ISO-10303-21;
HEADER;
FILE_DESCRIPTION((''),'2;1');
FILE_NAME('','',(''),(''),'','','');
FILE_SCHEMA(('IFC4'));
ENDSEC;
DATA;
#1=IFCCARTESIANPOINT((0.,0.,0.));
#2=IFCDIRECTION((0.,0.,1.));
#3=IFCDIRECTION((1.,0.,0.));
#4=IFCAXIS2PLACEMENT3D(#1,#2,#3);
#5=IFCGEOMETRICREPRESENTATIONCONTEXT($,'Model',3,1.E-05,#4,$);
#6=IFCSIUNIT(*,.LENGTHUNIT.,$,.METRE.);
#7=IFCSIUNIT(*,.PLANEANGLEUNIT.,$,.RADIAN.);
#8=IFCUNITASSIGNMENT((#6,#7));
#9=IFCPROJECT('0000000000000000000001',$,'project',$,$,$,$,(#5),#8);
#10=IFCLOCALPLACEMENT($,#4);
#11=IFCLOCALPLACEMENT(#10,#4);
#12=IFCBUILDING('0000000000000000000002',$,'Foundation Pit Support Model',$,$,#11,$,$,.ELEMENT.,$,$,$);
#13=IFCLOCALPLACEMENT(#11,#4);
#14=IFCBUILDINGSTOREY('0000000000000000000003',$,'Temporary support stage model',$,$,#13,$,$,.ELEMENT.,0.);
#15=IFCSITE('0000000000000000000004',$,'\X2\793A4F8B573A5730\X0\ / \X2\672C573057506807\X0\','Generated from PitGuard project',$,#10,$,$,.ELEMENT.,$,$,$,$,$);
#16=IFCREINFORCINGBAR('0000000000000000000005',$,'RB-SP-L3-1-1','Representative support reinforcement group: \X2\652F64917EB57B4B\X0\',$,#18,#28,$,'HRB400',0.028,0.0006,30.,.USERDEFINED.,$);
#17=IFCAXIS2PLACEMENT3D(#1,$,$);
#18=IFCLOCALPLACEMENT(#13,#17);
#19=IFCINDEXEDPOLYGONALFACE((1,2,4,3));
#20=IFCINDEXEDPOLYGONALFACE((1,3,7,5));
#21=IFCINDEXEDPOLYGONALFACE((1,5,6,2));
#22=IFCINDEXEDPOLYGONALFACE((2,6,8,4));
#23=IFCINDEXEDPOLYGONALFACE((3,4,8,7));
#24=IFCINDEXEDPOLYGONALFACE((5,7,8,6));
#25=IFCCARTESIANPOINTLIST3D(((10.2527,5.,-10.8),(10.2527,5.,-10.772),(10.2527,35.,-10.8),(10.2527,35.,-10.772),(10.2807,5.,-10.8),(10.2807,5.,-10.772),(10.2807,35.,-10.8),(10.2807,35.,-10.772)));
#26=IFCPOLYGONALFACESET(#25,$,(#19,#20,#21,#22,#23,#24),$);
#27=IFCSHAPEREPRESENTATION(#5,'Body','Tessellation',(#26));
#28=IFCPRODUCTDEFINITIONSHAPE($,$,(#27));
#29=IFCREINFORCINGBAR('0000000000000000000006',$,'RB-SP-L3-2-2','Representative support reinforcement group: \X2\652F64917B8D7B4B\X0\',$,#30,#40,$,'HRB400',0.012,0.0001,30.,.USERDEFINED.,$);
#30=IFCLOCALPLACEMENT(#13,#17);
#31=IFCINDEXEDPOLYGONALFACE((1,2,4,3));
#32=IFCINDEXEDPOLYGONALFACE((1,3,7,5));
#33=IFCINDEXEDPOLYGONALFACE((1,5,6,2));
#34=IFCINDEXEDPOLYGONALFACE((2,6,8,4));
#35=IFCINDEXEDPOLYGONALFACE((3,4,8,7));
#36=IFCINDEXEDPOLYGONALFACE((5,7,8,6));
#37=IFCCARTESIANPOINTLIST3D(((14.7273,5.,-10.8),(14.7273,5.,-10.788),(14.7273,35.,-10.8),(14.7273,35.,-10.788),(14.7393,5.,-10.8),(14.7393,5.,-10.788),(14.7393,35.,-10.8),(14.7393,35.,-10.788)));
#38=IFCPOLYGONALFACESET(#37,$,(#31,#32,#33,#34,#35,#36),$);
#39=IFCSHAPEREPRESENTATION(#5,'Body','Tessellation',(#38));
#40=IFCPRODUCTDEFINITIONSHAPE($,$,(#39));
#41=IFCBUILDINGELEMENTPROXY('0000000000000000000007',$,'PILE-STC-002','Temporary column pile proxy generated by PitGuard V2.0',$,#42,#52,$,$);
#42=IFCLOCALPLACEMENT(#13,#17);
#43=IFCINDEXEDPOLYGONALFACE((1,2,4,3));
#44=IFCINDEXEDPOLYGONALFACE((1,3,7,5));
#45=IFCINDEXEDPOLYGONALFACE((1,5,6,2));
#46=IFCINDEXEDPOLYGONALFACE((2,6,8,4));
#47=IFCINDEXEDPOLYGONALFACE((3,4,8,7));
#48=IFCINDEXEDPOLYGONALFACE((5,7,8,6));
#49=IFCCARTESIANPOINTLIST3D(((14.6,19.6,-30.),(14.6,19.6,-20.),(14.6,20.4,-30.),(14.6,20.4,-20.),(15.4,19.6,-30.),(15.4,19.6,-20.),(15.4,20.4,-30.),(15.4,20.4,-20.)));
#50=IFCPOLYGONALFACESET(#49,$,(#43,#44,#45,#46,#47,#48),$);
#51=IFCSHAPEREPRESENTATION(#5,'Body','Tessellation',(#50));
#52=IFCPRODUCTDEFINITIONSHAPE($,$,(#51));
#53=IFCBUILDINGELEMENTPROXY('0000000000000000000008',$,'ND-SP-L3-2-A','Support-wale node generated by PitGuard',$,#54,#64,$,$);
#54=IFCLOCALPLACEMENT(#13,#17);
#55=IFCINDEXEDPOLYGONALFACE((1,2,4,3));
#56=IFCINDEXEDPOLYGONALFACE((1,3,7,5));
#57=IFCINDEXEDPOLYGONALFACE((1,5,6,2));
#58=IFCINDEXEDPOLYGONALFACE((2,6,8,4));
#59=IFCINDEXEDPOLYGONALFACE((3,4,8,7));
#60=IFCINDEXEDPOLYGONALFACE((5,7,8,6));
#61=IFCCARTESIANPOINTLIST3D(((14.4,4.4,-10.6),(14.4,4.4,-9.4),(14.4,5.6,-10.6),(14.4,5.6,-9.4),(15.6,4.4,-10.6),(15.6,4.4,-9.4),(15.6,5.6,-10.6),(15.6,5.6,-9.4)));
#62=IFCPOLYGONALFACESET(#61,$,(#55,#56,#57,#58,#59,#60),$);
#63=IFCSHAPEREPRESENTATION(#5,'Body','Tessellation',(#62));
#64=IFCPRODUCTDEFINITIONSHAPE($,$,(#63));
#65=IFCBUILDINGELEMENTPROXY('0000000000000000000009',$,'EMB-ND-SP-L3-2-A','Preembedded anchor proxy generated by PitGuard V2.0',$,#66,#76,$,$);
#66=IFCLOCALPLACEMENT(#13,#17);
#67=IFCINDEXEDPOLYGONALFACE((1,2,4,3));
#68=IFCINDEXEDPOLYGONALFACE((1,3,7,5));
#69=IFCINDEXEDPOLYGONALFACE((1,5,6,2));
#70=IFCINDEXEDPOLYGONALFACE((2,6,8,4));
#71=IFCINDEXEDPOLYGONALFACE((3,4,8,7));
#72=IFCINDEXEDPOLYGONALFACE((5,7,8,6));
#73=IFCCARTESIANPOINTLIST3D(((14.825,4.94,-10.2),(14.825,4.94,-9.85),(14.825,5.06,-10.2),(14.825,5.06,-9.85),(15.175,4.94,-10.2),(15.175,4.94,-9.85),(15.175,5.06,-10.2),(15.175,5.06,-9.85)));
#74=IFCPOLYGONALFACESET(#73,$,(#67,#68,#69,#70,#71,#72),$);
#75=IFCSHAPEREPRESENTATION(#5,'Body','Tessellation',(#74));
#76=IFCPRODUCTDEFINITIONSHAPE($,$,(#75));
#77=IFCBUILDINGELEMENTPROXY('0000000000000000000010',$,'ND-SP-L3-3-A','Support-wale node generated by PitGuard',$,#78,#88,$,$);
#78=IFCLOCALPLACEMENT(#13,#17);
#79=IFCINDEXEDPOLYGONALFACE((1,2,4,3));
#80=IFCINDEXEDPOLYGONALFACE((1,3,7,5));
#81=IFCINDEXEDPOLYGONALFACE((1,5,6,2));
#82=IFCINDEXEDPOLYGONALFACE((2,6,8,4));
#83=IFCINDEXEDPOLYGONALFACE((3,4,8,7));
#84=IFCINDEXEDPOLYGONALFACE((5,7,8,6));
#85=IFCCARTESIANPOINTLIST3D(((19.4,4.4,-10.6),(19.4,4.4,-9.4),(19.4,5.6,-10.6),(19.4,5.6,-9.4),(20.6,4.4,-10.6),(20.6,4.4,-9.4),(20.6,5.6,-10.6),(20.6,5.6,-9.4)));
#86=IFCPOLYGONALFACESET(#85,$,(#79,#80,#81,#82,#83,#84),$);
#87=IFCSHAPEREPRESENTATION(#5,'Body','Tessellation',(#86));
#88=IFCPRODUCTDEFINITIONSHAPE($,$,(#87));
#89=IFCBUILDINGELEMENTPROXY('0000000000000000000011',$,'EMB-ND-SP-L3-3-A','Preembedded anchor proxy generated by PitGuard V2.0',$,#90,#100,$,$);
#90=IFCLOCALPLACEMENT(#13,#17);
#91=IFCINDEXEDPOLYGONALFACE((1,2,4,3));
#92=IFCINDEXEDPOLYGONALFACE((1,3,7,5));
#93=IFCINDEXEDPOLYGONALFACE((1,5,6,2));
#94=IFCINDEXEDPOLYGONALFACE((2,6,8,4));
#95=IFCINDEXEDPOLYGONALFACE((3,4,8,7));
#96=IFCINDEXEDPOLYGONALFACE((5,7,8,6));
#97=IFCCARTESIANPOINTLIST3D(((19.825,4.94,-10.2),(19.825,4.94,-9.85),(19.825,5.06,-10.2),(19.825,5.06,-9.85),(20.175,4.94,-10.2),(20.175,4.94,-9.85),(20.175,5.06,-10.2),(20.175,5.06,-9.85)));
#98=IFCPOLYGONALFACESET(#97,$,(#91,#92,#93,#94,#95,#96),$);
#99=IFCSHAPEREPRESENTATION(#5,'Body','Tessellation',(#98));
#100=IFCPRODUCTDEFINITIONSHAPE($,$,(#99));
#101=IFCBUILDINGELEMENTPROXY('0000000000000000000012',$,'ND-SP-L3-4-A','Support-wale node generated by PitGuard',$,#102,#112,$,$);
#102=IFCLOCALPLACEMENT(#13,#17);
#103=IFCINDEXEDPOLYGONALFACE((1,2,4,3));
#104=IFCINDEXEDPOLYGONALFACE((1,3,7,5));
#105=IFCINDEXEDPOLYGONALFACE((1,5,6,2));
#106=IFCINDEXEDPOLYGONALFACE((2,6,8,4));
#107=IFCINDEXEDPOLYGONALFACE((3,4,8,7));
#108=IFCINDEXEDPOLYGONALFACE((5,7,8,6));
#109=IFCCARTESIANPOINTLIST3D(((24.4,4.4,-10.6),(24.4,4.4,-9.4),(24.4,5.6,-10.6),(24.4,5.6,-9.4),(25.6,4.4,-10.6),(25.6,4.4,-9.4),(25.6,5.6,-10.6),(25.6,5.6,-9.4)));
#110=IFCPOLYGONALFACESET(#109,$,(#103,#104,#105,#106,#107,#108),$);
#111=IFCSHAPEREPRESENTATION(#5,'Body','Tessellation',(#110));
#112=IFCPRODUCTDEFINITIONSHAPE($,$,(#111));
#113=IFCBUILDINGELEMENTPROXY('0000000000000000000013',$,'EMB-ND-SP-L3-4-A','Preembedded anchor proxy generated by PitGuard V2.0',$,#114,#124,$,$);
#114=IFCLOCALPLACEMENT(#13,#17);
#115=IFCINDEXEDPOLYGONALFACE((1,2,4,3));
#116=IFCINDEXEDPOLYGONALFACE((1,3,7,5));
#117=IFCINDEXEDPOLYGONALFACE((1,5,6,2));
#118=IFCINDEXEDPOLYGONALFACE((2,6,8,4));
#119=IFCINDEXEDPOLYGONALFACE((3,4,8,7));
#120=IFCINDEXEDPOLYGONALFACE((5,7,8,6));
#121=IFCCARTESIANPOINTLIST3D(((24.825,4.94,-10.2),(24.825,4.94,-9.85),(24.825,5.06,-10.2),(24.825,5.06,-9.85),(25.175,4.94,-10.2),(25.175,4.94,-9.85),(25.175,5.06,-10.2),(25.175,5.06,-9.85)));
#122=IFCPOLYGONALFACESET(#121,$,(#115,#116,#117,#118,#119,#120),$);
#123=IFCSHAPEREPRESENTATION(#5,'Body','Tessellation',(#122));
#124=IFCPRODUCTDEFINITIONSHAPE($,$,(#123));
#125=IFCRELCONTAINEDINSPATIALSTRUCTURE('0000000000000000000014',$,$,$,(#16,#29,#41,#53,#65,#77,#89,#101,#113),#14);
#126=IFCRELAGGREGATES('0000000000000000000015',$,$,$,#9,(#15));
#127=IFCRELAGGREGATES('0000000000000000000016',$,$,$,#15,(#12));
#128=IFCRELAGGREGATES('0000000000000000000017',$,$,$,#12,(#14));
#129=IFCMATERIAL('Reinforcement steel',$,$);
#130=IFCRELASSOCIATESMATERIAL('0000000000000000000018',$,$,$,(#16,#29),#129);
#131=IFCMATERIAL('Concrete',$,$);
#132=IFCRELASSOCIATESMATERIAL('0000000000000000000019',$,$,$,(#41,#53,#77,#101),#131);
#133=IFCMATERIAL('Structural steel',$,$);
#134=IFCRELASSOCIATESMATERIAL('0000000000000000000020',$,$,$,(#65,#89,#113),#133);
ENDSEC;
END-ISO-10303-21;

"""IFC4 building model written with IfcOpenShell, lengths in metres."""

from ifc_helpers import new_model, si_unit, frame, origin_with_axes, origin_2d, place, context, project, spatial, rectangle, extrude, material, element, save


model = new_model("IFC4")

# Units and contexts
model_context = context("Model", 3, precision=1e-05, world=origin_with_axes())
ifc_project = project(units=[si_unit("LENGTHUNIT", "METRE"), si_unit("PLANEANGLEUNIT", "RADIAN")], contexts=[model_context])

# Site, building, storey
site_placement = place(None, origin_with_axes())
site = spatial("IfcSite", under=ifc_project, at=site_placement, Name="示例场地 / 本地坐标", Description="Generated from PitGuard project", CompositionType="ELEMENT")
building_placement = place(site_placement, origin_with_axes())
building = spatial("IfcBuilding", under=site, at=building_placement, Name="Foundation Pit Support Model", CompositionType="ELEMENT")
storey_placement = place(building_placement, origin_with_axes())
storey = spatial("IfcBuildingStorey", under=building, at=storey_placement, Name="Temporary support stage model", CompositionType="ELEMENT", Elevation=0.0)

# Shared definitions
ifc_material_1 = material(Name="Structural steel")

# Shared definitions
ifc_material_2 = material(Name="Concrete")

# Reinforcing bars
ifc_material_3 = material(Name="Reinforcement steel")
reinforcing_bar_1_placement = place(storey_placement, frame((10.2667, 20.0, -10.8), z_axis=(0.0, 0.0, 1.0), x_axis=(0.0, 1.0, 0.0)))
element("IfcReinforcingBar", 1, at=reinforcing_bar_1_placement, inside=storey, material=ifc_material_3, Name="RB-SP-L3-1-1", Description="Representative support reinforcement group: 支撑纵筋", SteelGrade="HRB400", BarLength=30.0, CrossSectionArea=0.0006, NominalDiameter=0.028, PredefinedType="USERDEFINED", context=model_context, shape_type="SweptSolid", body=[
    extrude(rectangle(XDim=30.0, YDim=0.028, at=origin_2d()), origin_with_axes(), (0.0, 0.0, 1.0), 0.028),
])
reinforcing_bar_2_placement = place(storey_placement, frame((14.7333, 20.0, -10.8), z_axis=(0.0, 0.0, 1.0), x_axis=(0.0, 1.0, 0.0)))
element("IfcReinforcingBar", 2, at=reinforcing_bar_2_placement, inside=storey, material=ifc_material_3, Name="RB-SP-L3-2-2", Description="Representative support reinforcement group: 支撑箍筋", SteelGrade="HRB400", BarLength=30.0, CrossSectionArea=0.0001, NominalDiameter=0.012, PredefinedType="USERDEFINED", context=model_context, shape_type="SweptSolid", body=[
    extrude(rectangle(XDim=30.0, YDim=0.012, at=origin_2d()), origin_with_axes(), (0.0, 0.0, 1.0), 0.012),
])

# Building element proxies
proxy_1_placement = place(storey_placement, frame((15.0, 20.0, -30.0), z_axis=(0.0, 0.0, 1.0), x_axis=(1.0, 0.0, 0.0)))
element("IfcBuildingElementProxy", 3, at=proxy_1_placement, inside=storey, material=ifc_material_2, Name="PILE-STC-002", Description="Temporary column pile proxy generated by PitGuard V2.0", context=model_context, shape_type="SweptSolid", body=[
    extrude(rectangle(XDim=0.8, YDim=0.8, at=origin_2d()), origin_with_axes(), (0.0, 0.0, 1.0), 10.0),
])
proxy_2_placement = place(storey_placement, frame((15.0, 5.0, -10.6), z_axis=(0.0, 0.0, 1.0), x_axis=(1.0, 0.0, 0.0)))
element("IfcBuildingElementProxy", 4, at=proxy_2_placement, inside=storey, material=ifc_material_2, Name="ND-SP-L3-2-A", Description="Support-wale node generated by PitGuard", context=model_context, shape_type="SweptSolid", body=[
    extrude(rectangle(XDim=1.2, YDim=1.2, at=origin_2d()), origin_with_axes(), (0.0, 0.0, 1.0), 1.2),
])
proxy_3_placement = place(storey_placement, frame((15.0, 5.0, -10.2), z_axis=(0.0, 0.0, 1.0), x_axis=(1.0, 0.0, 0.0)))
element("IfcBuildingElementProxy", 5, at=proxy_3_placement, inside=storey, material=ifc_material_1, Name="EMB-ND-SP-L3-2-A", Description="Preembedded anchor proxy generated by PitGuard V2.0", context=model_context, shape_type="SweptSolid", body=[
    extrude(rectangle(XDim=0.35, YDim=0.12, at=origin_2d()), origin_with_axes(), (0.0, 0.0, 1.0), 0.35),
])
proxy_4_placement = place(storey_placement, frame((20.0, 5.0, -10.6), z_axis=(0.0, 0.0, 1.0), x_axis=(1.0, 0.0, 0.0)))
element("IfcBuildingElementProxy", 6, at=proxy_4_placement, inside=storey, material=ifc_material_2, Name="ND-SP-L3-3-A", Description="Support-wale node generated by PitGuard", context=model_context, shape_type="SweptSolid", body=[
    extrude(rectangle(XDim=1.2, YDim=1.2, at=origin_2d()), origin_with_axes(), (0.0, 0.0, 1.0), 1.2),
])
proxy_5_placement = place(storey_placement, frame((20.0, 5.0, -10.2), z_axis=(0.0, 0.0, 1.0), x_axis=(1.0, 0.0, 0.0)))
element("IfcBuildingElementProxy", 7, at=proxy_5_placement, inside=storey, material=ifc_material_1, Name="EMB-ND-SP-L3-3-A", Description="Preembedded anchor proxy generated by PitGuard V2.0", context=model_context, shape_type="SweptSolid", body=[
    extrude(rectangle(XDim=0.35, YDim=0.12, at=origin_2d()), origin_with_axes(), (0.0, 0.0, 1.0), 0.35),
])
proxy_6_placement = place(storey_placement, frame((25.0, 5.0, -10.6), z_axis=(0.0, 0.0, 1.0), x_axis=(1.0, 0.0, 0.0)))
element("IfcBuildingElementProxy", 8, at=proxy_6_placement, inside=storey, material=ifc_material_2, Name="ND-SP-L3-4-A", Description="Support-wale node generated by PitGuard", context=model_context, shape_type="SweptSolid", body=[
    extrude(rectangle(XDim=1.2, YDim=1.2, at=origin_2d()), origin_with_axes(), (0.0, 0.0, 1.0), 1.2),
])
proxy_7_placement = place(storey_placement, frame((25.0, 5.0, -10.2), z_axis=(0.0, 0.0, 1.0), x_axis=(1.0, 0.0, 0.0)))
element("IfcBuildingElementProxy", 9, at=proxy_7_placement, inside=storey, material=ifc_material_1, Name="EMB-ND-SP-L3-4-A", Description="Preembedded anchor proxy generated by PitGuard V2.0", context=model_context, shape_type="SweptSolid", body=[
    extrude(rectangle(XDim=0.35, YDim=0.12, at=origin_2d()), origin_with_axes(), (0.0, 0.0, 1.0), 0.35),
])

save(model, "model.ifc")
